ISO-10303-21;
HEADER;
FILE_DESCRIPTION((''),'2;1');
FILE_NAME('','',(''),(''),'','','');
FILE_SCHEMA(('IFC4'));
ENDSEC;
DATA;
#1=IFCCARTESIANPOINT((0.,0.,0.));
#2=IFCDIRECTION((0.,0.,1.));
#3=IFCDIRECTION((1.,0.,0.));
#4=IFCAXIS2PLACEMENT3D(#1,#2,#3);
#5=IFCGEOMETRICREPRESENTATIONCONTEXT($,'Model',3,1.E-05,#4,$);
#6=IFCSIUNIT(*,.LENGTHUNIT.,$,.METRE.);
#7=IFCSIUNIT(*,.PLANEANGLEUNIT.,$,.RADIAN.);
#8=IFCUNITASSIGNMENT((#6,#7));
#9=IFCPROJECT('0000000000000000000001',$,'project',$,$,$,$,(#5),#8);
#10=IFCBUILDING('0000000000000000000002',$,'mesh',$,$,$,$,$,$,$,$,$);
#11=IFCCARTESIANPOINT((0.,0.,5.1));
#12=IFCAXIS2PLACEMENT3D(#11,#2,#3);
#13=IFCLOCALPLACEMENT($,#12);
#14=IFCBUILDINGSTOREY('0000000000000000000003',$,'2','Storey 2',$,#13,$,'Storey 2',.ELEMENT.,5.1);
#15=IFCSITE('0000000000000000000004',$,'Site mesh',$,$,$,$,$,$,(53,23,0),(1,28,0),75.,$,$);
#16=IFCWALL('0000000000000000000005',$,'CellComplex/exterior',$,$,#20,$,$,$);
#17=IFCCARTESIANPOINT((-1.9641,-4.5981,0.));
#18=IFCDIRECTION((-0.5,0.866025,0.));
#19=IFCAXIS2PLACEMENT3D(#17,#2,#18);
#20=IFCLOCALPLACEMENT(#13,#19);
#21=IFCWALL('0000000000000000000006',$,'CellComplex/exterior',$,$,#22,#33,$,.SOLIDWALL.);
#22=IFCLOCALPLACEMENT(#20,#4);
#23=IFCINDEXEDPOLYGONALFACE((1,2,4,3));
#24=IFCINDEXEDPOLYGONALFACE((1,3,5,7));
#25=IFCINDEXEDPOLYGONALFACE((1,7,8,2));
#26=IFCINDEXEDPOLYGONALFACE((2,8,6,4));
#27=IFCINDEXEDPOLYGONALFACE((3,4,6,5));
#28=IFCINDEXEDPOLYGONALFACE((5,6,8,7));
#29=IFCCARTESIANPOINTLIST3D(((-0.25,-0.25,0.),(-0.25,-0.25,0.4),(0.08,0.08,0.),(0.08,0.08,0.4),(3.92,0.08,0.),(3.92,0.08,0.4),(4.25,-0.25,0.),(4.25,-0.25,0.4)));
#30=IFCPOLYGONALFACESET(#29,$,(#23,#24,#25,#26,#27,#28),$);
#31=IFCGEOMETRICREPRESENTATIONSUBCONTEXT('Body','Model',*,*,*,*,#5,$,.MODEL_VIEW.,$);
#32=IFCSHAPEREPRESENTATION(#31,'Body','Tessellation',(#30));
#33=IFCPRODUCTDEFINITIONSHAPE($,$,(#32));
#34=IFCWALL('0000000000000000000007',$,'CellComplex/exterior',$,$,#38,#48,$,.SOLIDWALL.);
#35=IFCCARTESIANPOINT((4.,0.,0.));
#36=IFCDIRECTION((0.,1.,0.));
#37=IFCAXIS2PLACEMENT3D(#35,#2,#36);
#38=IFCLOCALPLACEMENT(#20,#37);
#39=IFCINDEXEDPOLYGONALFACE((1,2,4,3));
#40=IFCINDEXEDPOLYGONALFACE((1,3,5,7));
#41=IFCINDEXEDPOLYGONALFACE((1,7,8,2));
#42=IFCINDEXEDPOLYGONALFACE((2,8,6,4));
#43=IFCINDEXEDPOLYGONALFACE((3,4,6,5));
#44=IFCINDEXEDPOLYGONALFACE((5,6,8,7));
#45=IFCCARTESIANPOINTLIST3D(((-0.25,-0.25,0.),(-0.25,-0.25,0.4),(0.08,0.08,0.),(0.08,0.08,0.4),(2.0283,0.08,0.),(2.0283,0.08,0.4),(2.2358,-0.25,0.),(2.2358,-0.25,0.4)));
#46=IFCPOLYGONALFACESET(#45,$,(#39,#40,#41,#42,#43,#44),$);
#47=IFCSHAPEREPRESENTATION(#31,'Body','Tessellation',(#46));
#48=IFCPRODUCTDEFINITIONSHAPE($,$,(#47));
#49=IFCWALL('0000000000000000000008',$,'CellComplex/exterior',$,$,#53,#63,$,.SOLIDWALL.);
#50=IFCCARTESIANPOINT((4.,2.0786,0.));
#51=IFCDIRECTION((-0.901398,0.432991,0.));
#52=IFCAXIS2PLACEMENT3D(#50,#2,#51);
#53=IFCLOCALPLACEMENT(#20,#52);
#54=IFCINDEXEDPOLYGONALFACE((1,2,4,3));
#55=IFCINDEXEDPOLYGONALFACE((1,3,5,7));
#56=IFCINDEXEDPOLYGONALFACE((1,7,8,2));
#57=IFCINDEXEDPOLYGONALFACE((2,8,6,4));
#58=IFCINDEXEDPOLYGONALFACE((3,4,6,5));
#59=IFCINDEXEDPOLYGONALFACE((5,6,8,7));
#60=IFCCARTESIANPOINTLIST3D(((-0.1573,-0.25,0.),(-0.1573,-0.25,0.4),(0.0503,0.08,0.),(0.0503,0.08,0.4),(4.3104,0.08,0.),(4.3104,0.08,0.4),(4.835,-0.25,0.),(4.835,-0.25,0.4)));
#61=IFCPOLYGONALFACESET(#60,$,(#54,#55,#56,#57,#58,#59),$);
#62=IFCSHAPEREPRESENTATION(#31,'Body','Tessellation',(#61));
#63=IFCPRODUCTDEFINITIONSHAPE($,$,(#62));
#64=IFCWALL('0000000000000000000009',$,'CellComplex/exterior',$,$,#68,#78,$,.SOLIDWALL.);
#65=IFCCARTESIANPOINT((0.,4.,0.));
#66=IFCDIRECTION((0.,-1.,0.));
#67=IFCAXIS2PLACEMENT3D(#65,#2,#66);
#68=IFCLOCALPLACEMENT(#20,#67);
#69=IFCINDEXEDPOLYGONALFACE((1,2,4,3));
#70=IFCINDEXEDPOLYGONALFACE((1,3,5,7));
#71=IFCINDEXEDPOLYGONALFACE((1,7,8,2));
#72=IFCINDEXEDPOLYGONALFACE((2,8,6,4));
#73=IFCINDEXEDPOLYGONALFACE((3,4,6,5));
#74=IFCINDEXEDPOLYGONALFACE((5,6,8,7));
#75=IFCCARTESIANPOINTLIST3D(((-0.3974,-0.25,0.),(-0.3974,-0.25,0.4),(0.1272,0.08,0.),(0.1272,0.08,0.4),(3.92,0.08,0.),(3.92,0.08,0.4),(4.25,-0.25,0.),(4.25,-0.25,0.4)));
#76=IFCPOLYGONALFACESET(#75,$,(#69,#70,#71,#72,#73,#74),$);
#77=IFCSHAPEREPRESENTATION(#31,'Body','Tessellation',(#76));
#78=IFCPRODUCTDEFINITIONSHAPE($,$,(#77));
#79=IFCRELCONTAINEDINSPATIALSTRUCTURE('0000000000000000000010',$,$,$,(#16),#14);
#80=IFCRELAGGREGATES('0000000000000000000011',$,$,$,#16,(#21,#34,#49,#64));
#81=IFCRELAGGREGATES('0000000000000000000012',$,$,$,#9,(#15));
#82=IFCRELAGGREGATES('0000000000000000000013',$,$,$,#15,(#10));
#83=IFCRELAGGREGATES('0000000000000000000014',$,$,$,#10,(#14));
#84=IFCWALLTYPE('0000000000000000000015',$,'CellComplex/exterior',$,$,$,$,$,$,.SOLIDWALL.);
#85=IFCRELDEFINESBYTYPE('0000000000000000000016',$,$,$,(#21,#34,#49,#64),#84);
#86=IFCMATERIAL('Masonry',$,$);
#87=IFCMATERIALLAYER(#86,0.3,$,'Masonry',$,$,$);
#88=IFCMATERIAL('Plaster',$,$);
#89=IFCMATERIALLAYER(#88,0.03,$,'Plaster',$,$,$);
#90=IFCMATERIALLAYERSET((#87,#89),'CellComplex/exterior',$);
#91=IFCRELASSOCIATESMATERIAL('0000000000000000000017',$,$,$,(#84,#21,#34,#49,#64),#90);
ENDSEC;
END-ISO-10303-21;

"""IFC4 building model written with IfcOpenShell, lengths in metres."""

from ifc_helpers import new_model, si_unit, frame, origin, origin_with_axes, place, context, subcontext, project, spatial, polyline, outline, extrude, material, layer, layer_set, layer_usage, type_object, element, aggregate, save


model = new_model("IFC4")

# Units and contexts
model_context = context("Model", 3, precision=1e-05, world=origin_with_axes())
body_context = subcontext(model_context, "Body", "Model", "MODEL_VIEW")
ifc_project = project(units=[si_unit("LENGTHUNIT", "METRE"), si_unit("PLANEANGLEUNIT", "RADIAN")], contexts=[model_context])

# Site, building, storey
site = spatial("IfcSite", under=ifc_project, Name="Site mesh", RefLatitude=(53, 23, 0), RefLongitude=(1, 28, 0), RefElevation=75.0)
building = spatial("IfcBuilding", under=site, Name="mesh")
storey_placement = place(None, frame((0.0, 0.0, 5.1), z_axis=(0.0, 0.0, 1.0), x_axis=(1.0, 0.0, 0.0)))
storey = spatial("IfcBuildingStorey", under=building, at=storey_placement, Name="2", Description="Storey 2", LongName="Storey 2", CompositionType="ELEMENT", Elevation=5.1)

# Walls
wall_1_placement = place(storey_placement, frame((-1.9641, -4.5981, 0.0), z_axis=(0.0, 0.0, 1.0), x_axis=(-0.5, 0.866025, 0.0)))
wall_1 = element("IfcWall", 1, at=wall_1_placement, inside=storey, Name="CellComplex/exterior")
ifc_material_1 = material(Name="Masonry")
ifc_layer_1 = layer(ifc_material_1, 0.3, Name="Masonry")
ifc_material_2 = material(Name="Plaster")
ifc_layer_2 = layer(ifc_material_2, 0.03, Name="Plaster")
ifc_layer_set = layer_set([ifc_layer_1, ifc_layer_2], Name="CellComplex/exterior")
ifc_layer_usage_1 = layer_usage(ifc_layer_set, "AXIS2", "POSITIVE", -0.25)
wall_type = type_object("IfcWallType", Name="CellComplex/exterior", PredefinedType="SOLIDWALL", material=ifc_layer_set)
wall_2_placement = place(wall_1_placement, frame((0.0, 0.0, 0.0), z_axis=(0.0, 0.0, 1.0), x_axis=(1.0, 0.0, 0.0)))
wall_2 = element("IfcWall", 2, at=wall_2_placement, type_object=wall_type, material=ifc_layer_usage_1, Name="CellComplex/exterior", PredefinedType="SOLIDWALL", context=body_context, shape_type="SweptSolid", body=[
    extrude(outline(polyline([(0.08, 0.08), (-0.25, -0.25), (4.25, -0.25), (3.92, 0.08), (0.08, 0.08)])), origin(), (0.0, 0.0, 1.0), 0.4),
])
ifc_layer_usage_2 = layer_usage(ifc_layer_set, "AXIS2", "POSITIVE", -0.25)
wall_3_placement = place(wall_1_placement, frame((4.0, 0.0, 0.0), z_axis=(0.0, 0.0, 1.0), x_axis=(0.0, 1.0, 0.0)))
wall_3 = element("IfcWall", 3, at=wall_3_placement, type_object=wall_type, material=ifc_layer_usage_2, Name="CellComplex/exterior", PredefinedType="SOLIDWALL", context=body_context, shape_type="SweptSolid", body=[
    extrude(outline(polyline([(0.08, 0.08), (-0.25, -0.25), (2.2358, -0.25), (2.0283, 0.08), (0.08, 0.08)])), origin(), (0.0, 0.0, 1.0), 0.4),
])
ifc_layer_usage_3 = layer_usage(ifc_layer_set, "AXIS2", "POSITIVE", -0.25)
wall_4_placement = place(wall_1_placement, frame((4.0, 2.0786, 0.0), z_axis=(0.0, 0.0, 1.0), x_axis=(-0.901398, 0.432991, 0.0)))
wall_4 = element("IfcWall", 4, at=wall_4_placement, type_object=wall_type, material=ifc_layer_usage_3, Name="CellComplex/exterior", PredefinedType="SOLIDWALL", context=body_context, shape_type="SweptSolid", body=[
    extrude(outline(polyline([(0.0503, 0.08), (-0.1573, -0.25), (4.835, -0.25), (4.3104, 0.08), (0.0503, 0.08)])), origin(), (0.0, 0.0, 1.0), 0.4),
])
ifc_layer_usage_4 = layer_usage(ifc_layer_set, "AXIS2", "POSITIVE", -0.25)
wall_5_placement = place(wall_1_placement, frame((0.0, 4.0, 0.0), z_axis=(0.0, 0.0, 1.0), x_axis=(0.0, -1.0, 0.0)))
wall_5 = element("IfcWall", 5, at=wall_5_placement, type_object=wall_type, material=ifc_layer_usage_4, Name="CellComplex/exterior", PredefinedType="SOLIDWALL", context=body_context, shape_type="SweptSolid", body=[
    extrude(outline(polyline([(0.1272, 0.08), (-0.3974, -0.25), (4.25, -0.25), (3.92, 0.08), (0.1272, 0.08)])), origin(), (0.0, 0.0, 1.0), 0.4),
])
aggregate(wall_1, [wall_2, wall_3, wall_4, wall_5])

save(model, "model.ifc")
